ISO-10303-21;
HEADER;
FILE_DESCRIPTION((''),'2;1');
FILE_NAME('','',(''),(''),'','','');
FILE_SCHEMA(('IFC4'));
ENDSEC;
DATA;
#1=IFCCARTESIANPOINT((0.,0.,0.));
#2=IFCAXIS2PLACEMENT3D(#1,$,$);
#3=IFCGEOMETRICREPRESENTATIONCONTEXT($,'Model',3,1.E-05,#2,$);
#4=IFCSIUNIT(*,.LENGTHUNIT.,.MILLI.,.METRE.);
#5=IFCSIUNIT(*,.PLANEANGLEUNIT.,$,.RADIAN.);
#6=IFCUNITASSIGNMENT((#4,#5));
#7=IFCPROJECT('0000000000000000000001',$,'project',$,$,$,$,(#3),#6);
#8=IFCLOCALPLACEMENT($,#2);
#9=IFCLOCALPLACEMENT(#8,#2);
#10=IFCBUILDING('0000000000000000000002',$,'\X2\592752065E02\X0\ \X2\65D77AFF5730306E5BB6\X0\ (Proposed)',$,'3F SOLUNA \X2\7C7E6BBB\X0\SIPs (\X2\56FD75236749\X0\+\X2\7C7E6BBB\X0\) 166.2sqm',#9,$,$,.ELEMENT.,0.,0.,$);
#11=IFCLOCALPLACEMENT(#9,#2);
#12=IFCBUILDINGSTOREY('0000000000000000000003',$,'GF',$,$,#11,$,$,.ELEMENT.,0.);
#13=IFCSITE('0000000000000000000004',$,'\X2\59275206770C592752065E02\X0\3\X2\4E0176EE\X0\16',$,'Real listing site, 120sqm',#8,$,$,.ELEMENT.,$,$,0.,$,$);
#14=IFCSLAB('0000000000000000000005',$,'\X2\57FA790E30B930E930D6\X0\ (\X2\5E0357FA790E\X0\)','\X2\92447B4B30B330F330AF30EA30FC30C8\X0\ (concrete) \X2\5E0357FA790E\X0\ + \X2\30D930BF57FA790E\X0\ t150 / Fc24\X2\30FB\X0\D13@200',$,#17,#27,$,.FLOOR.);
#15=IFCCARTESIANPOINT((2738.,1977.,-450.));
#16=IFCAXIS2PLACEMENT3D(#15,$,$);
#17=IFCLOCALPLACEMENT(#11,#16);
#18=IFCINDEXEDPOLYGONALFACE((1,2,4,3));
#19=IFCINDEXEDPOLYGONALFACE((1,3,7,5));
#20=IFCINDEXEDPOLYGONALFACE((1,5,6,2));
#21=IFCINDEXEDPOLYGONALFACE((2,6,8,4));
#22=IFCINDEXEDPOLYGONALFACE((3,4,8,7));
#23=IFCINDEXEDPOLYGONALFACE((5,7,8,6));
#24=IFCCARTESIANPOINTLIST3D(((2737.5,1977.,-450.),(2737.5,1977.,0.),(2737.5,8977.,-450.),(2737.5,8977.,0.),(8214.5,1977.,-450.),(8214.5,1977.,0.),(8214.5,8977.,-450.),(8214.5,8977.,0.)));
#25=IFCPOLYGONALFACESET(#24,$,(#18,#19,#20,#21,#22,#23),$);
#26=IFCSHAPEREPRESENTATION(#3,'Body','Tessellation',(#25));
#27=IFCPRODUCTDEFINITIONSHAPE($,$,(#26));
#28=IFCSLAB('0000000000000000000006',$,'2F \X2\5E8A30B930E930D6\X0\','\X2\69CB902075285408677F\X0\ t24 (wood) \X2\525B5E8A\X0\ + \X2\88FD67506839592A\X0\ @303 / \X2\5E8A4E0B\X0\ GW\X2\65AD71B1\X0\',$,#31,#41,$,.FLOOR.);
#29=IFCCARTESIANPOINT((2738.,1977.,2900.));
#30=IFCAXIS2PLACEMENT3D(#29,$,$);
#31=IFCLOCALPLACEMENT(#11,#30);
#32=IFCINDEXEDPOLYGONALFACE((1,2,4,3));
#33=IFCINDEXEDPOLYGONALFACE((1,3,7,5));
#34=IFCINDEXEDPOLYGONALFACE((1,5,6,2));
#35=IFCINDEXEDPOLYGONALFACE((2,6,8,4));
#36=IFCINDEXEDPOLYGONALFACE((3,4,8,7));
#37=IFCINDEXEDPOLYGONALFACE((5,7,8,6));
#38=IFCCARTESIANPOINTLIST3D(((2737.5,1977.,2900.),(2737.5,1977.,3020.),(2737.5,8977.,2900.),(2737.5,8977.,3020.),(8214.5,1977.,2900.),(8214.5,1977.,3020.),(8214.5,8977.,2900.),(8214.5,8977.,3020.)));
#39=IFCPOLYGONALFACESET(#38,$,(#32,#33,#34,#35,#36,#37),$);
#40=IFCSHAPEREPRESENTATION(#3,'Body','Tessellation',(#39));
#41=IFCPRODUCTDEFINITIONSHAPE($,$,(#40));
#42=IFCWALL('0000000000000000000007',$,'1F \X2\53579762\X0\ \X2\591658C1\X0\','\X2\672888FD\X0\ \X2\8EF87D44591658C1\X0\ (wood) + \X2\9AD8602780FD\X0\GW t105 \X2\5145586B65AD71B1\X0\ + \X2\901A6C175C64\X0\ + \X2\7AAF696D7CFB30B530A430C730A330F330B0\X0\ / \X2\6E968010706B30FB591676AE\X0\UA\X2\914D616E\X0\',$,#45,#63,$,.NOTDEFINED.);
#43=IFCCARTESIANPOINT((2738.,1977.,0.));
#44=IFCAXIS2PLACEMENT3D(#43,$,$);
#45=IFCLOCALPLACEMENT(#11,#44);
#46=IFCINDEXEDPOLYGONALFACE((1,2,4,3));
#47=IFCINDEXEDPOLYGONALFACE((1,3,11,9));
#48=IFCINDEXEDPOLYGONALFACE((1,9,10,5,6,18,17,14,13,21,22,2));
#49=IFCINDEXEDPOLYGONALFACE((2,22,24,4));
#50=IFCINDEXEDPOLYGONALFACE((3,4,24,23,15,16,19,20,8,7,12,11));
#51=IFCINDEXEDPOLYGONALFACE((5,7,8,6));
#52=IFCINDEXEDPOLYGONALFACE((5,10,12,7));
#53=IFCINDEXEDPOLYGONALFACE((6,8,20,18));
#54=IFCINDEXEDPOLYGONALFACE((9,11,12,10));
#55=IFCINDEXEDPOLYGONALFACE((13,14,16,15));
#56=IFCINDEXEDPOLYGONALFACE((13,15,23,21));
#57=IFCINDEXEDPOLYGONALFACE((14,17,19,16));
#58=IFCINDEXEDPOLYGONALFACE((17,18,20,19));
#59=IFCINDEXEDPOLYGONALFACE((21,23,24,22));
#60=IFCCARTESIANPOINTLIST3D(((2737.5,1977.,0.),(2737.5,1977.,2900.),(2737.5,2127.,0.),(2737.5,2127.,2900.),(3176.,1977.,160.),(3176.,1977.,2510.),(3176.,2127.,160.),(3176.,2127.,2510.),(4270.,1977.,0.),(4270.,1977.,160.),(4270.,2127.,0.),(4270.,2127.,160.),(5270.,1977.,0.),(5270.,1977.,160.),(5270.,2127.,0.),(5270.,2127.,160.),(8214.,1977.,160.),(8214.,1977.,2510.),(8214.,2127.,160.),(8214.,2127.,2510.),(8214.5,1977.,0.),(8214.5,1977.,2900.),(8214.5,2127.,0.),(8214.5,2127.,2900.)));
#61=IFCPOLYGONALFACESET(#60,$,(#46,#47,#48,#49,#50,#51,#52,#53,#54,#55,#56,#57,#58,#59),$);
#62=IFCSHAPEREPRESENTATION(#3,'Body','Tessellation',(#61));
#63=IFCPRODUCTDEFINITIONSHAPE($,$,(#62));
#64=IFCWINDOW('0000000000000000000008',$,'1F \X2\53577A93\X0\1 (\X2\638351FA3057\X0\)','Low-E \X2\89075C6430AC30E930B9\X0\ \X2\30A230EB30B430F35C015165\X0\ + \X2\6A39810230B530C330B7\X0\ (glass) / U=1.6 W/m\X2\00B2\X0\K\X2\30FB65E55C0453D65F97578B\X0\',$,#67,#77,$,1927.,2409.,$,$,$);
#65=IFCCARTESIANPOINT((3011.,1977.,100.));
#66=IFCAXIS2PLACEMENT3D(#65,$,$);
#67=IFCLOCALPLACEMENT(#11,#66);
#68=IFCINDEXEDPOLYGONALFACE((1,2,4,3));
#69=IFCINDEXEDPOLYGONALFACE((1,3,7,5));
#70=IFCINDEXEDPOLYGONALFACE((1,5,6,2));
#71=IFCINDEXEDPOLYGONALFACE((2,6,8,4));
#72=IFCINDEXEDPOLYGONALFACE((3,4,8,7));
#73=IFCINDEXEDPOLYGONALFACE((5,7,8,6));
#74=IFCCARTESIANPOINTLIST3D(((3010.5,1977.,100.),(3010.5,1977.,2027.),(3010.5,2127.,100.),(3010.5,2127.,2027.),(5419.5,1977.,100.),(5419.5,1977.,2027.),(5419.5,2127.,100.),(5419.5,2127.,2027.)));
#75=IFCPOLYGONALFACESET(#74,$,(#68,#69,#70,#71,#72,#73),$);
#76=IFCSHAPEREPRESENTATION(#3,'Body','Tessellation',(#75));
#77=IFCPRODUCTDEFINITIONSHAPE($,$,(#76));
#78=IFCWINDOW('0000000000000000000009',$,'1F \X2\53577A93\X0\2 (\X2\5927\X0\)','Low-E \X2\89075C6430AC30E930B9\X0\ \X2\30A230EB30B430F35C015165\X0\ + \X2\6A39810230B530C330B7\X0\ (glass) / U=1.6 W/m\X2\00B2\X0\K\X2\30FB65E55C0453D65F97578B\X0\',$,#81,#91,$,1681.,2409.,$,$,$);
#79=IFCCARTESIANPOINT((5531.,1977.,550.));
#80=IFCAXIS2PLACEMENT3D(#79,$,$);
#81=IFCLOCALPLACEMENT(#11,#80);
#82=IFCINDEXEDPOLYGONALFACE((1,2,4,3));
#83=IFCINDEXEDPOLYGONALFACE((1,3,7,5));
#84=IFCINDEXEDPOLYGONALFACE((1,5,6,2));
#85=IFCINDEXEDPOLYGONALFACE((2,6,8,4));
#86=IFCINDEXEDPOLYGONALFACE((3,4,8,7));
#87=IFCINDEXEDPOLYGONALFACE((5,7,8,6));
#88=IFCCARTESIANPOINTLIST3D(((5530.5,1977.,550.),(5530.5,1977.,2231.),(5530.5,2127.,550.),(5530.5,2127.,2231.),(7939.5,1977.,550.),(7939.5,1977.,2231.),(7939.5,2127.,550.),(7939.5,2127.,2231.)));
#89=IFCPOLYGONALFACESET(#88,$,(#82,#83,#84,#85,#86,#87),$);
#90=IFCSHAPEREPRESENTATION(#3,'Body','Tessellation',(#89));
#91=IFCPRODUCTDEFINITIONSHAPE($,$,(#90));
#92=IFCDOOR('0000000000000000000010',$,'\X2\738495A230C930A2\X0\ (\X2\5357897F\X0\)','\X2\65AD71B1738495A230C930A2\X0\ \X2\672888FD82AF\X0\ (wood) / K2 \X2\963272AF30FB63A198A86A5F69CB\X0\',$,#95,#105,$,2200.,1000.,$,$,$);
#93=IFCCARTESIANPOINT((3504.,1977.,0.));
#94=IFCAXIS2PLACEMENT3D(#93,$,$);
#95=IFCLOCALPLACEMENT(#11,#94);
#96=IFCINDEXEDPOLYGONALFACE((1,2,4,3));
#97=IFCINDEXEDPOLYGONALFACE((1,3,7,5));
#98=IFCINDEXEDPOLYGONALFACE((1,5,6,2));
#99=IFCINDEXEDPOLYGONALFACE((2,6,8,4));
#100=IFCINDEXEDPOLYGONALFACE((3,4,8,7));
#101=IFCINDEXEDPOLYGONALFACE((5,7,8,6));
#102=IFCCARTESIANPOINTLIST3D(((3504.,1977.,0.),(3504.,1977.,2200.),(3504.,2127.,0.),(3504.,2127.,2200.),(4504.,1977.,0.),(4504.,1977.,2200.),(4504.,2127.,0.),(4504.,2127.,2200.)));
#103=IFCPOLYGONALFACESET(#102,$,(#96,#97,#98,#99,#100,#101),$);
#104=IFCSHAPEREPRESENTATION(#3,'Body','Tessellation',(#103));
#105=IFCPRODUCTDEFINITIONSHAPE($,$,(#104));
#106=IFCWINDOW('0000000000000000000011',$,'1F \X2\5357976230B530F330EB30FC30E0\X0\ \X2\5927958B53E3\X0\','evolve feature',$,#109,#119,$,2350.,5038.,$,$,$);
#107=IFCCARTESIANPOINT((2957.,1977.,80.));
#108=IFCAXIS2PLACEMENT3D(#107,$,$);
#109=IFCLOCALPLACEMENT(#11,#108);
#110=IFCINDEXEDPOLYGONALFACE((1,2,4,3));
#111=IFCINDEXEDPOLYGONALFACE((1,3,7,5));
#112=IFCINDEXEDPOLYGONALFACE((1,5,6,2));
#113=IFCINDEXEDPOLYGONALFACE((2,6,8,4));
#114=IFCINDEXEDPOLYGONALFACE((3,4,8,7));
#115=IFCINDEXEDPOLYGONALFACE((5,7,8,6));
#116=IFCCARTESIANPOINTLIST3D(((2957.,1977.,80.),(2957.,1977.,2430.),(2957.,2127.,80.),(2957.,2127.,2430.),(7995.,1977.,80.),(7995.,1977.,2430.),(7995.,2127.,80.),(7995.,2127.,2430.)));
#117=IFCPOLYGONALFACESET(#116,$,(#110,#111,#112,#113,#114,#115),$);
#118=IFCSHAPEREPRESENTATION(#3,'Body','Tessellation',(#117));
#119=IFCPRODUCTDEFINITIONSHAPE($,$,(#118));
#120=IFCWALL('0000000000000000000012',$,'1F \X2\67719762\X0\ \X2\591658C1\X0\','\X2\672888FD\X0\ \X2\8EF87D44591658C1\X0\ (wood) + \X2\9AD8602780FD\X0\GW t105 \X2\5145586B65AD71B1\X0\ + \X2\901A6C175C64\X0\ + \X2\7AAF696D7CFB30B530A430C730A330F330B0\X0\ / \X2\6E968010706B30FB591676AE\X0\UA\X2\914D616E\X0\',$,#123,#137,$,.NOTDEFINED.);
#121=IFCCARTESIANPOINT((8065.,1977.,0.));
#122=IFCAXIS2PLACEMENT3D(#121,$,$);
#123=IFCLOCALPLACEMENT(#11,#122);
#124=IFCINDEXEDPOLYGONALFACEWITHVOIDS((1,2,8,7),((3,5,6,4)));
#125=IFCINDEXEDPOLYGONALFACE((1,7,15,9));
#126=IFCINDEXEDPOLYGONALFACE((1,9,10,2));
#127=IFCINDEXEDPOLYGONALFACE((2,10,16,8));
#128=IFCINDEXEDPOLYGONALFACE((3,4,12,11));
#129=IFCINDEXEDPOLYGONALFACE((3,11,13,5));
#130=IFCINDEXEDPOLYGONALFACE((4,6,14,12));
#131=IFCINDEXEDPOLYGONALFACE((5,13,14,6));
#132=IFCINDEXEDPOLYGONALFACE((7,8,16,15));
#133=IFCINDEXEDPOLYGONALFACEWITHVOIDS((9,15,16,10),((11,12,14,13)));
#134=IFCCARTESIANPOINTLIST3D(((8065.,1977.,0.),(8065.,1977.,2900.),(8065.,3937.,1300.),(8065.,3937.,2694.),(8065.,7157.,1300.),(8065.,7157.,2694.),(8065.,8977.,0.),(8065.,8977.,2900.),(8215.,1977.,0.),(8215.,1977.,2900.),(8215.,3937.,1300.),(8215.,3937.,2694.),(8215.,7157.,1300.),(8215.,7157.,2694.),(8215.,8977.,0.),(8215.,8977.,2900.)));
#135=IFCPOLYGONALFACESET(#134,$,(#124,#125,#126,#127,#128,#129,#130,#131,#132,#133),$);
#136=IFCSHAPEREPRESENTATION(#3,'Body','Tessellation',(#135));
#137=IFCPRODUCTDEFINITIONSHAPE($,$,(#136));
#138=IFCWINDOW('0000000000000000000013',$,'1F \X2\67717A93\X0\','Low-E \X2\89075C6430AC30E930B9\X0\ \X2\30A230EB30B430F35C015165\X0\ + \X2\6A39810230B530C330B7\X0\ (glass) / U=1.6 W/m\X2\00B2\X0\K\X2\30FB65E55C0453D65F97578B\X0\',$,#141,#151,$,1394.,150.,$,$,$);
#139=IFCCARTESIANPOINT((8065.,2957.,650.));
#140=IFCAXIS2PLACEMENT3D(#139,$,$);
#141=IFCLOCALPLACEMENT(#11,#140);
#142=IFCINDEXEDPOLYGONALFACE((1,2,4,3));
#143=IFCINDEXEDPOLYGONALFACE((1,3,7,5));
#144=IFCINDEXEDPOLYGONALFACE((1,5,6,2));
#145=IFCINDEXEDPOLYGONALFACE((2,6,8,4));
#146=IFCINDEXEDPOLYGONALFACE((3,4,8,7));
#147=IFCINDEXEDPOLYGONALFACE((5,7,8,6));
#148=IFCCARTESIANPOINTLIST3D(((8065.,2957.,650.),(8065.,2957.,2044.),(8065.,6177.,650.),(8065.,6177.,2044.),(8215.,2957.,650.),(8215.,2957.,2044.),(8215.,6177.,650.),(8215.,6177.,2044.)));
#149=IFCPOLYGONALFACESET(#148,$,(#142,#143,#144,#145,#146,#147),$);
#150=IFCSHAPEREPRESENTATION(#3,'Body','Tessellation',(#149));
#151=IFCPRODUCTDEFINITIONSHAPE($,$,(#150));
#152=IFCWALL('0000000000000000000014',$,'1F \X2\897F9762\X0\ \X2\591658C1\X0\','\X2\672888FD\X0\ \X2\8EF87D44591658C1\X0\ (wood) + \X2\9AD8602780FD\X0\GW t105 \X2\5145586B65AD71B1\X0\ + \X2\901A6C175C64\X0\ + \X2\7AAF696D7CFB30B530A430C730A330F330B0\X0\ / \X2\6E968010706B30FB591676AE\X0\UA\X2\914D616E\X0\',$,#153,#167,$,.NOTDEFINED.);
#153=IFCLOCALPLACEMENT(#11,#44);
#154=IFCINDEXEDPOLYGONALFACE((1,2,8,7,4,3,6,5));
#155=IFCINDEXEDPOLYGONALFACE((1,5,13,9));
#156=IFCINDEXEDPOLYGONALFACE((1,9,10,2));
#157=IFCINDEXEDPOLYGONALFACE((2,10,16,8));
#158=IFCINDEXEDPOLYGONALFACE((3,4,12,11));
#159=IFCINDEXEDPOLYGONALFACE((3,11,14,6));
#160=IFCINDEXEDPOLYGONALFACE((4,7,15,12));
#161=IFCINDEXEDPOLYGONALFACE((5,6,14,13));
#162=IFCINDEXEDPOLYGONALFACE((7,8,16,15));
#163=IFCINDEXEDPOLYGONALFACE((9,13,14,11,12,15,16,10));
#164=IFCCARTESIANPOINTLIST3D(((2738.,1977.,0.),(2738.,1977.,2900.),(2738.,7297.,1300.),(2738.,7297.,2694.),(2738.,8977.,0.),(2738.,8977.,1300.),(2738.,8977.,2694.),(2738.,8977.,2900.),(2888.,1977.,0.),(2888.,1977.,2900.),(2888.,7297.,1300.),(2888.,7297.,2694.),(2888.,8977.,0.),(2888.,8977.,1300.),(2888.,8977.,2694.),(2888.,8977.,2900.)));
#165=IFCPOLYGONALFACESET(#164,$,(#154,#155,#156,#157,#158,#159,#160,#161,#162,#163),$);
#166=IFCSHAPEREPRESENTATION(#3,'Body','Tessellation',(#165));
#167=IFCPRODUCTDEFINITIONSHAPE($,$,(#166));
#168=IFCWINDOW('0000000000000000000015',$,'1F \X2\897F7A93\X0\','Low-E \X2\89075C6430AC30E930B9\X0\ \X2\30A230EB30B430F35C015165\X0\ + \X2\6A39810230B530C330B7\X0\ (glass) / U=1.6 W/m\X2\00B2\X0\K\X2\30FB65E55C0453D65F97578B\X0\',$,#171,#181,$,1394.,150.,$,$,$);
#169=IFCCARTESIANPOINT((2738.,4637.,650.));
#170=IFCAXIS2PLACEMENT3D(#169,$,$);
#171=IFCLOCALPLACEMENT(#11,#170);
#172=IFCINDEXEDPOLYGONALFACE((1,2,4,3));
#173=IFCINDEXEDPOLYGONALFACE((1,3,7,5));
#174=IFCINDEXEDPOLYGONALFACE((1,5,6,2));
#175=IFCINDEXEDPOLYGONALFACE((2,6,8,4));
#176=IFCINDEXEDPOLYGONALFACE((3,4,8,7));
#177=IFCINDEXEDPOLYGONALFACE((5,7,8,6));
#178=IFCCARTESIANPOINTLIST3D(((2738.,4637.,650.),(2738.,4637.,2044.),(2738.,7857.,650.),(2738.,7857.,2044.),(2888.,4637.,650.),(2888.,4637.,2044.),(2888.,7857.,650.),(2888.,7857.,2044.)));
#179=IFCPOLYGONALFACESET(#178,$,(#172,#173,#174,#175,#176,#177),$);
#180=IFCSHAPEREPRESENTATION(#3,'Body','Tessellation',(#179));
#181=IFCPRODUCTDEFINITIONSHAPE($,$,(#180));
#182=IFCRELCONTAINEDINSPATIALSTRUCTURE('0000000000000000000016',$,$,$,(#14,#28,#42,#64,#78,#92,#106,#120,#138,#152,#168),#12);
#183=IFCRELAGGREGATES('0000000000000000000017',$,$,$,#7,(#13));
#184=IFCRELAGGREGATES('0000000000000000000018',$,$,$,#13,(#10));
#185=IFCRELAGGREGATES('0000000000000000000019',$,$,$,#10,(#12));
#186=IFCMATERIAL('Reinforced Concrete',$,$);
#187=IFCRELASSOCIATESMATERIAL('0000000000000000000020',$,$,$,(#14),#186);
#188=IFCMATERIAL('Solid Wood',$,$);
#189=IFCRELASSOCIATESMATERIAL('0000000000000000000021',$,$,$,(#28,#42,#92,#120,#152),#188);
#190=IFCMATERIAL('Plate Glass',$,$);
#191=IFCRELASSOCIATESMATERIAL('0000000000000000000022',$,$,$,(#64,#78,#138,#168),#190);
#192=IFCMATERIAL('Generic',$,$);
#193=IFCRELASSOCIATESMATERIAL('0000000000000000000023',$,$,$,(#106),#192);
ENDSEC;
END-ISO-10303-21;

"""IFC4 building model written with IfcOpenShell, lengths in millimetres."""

from ifc_helpers import new_model, si_unit, frame, frame_2d, origin, place, context, project, spatial, rectangle, extrude, material, element, fill, save


model = new_model("IFC4")

# Units and contexts
model_context = context("Model", 3, precision=1e-05, world=origin())
ifc_project = project(units=[si_unit("LENGTHUNIT", "METRE", prefix="MILLI"), si_unit("PLANEANGLEUNIT", "RADIAN")], contexts=[model_context])

# Site, building, storey
site_placement = place(None, origin())
site = spatial("IfcSite", under=ifc_project, at=site_placement, Name="大分県大分市3丁目16", ObjectType="Real listing site, 120sqm", CompositionType="ELEMENT", RefElevation=0.0)
building_placement = place(site_placement, origin())
building = spatial("IfcBuilding", under=site, at=building_placement, Name="大分市 旗竿地の家 (Proposed)", ObjectType="3F SOLUNA 籾殻SIPs (国産杉+籾殻) 166.2sqm", CompositionType="ELEMENT", ElevationOfRefHeight=0.0, ElevationOfTerrain=0.0)
storey_placement = place(building_placement, origin())
storey = spatial("IfcBuildingStorey", under=building, at=storey_placement, Name="GF", CompositionType="ELEMENT", Elevation=0.0)

# Slabs
ifc_material_1 = material(Name="Reinforced Concrete")
slab_1_placement = place(storey_placement, frame((2738.0, 1977.0, -450.0)))
element("IfcSlab", 1, at=slab_1_placement, inside=storey, material=ifc_material_1, Name="基礎スラブ (布基礎)", Description="鉄筋コンクリート (concrete) 布基礎 + ベタ基礎 t150 / Fc24・D13@200", PredefinedType="FLOOR", context=model_context, shape_type="SweptSolid", body=[
    extrude(rectangle(XDim=5477.0, YDim=7000.0, at=frame_2d((2738.0, 3500.0))), frame((2738.0, 1977.0, -450.0)), (0.0, 0.0, 1.0), 450.0),
])
ifc_material_2 = material(Name="Solid Wood")
slab_2_placement = place(storey_placement, frame((2738.0, 1977.0, 2900.0)))
element("IfcSlab", 2, at=slab_2_placement, inside=storey, material=ifc_material_2, Name="2F 床スラブ", Description="構造用合板 t24 (wood) 剛床 + 製材根太 @303 / 床下 GW断熱", PredefinedType="FLOOR", context=model_context, shape_type="SweptSolid", body=[
    extrude(rectangle(XDim=5477.0, YDim=7000.0, at=frame_2d((2738.0, 3500.0))), frame((2738.0, 1977.0, 2900.0)), (0.0, 0.0, 1.0), 120.0),
])
ifc_material_3 = material(Name="Generic")

# Wall, openings, windows, door
wall_1_placement = place(storey_placement, frame((2738.0, 1977.0, 0.0)))
wall_1 = element("IfcWall", 3, at=wall_1_placement, inside=storey, material=ifc_material_2, Name="1F 南面 外壁", Description="木製 軸組外壁 (wood) + 高性能GW t105 充填断熱 + 通気層 + 窯業系サイディング / 準耐火・外皮UA配慮", PredefinedType="NOTDEFINED", context=model_context, shape_type="SweptSolid", body=[
    extrude(rectangle(XDim=5477.0, YDim=150.0, at=frame_2d((2738.0, 75.0))), frame((2738.0, 1977.0, 0.0)), (0.0, 0.0, 1.0), 2900.0),
])
opening_1_placement = place(storey_placement, frame((3011.0, 1977.0, 100.0)))
opening_1 = element("IfcOpeningElement", 4, at=opening_1_placement, cuts=wall_1, PredefinedType="NOTDEFINED", context=model_context, shape_type="SweptSolid", body=[
    extrude(rectangle(XDim=2409.0, YDim=150.0, at=frame_2d((1204.0, 75.0))), frame((3011.0, 1977.0, 100.0)), (0.0, 0.0, 1.0), 1927.0),
])
opening_2_placement = place(storey_placement, frame((5531.0, 1977.0, 550.0)))
opening_2 = element("IfcOpeningElement", 5, at=opening_2_placement, cuts=wall_1, PredefinedType="NOTDEFINED", context=model_context, shape_type="SweptSolid", body=[
    extrude(rectangle(XDim=2409.0, YDim=150.0, at=frame_2d((1204.0, 75.0))), frame((5531.0, 1977.0, 550.0)), (0.0, 0.0, 1.0), 1681.0),
])
opening_3_placement = place(storey_placement, frame((3504.0, 1977.0, 0.0)))
opening_3 = element("IfcOpeningElement", 6, at=opening_3_placement, cuts=wall_1, PredefinedType="NOTDEFINED", context=model_context, shape_type="SweptSolid", body=[
    extrude(rectangle(XDim=1000.0, YDim=150.0, at=frame_2d((500.0, 75.0))), frame((3504.0, 1977.0, 0.0)), (0.0, 0.0, 1.0), 2200.0),
])
opening_4_placement = place(storey_placement, frame((2957.0, 1977.0, 80.0)))
opening_4 = element("IfcOpeningElement", 7, at=opening_4_placement, cuts=wall_1, PredefinedType="NOTDEFINED", context=model_context, shape_type="SweptSolid", body=[
    extrude(rectangle(XDim=5038.0, YDim=150.0, at=frame_2d((2519.0, 75.0))), frame((2957.0, 1977.0, 80.0)), (0.0, 0.0, 1.0), 2350.0),
])
ifc_material_4 = material(Name="Plate Glass")
window_1_placement = place(storey_placement, frame((3011.0, 1977.0, 100.0)))
window_1 = element("IfcWindow", 8, at=window_1_placement, inside=storey, material=ifc_material_4, Name="1F 南窓1 (掃出し)", Description="Low-E 複層ガラス アルゴン封入 + 樹脂サッシ (glass) / U=1.6 W/m²K・日射取得型", OverallHeight=1927.0, OverallWidth=2409.0, context=model_context, shape_type="SweptSolid", body=[
    extrude(rectangle(XDim=2409.0, YDim=150.0, at=frame_2d((1204.0, 75.0))), frame((3011.0, 1977.0, 100.0)), (0.0, 0.0, 1.0), 1927.0),
])
fill(opening_1, window_1)
window_2_placement = place(storey_placement, frame((5531.0, 1977.0, 550.0)))
window_2 = element("IfcWindow", 9, at=window_2_placement, inside=storey, material=ifc_material_4, Name="1F 南窓2 (大)", Description="Low-E 複層ガラス アルゴン封入 + 樹脂サッシ (glass) / U=1.6 W/m²K・日射取得型", OverallHeight=1681.0, OverallWidth=2409.0, context=model_context, shape_type="SweptSolid", body=[
    extrude(rectangle(XDim=2409.0, YDim=150.0, at=frame_2d((1204.0, 75.0))), frame((5531.0, 1977.0, 550.0)), (0.0, 0.0, 1.0), 1681.0),
])
fill(opening_2, window_2)
door_placement = place(storey_placement, frame((3504.0, 1977.0, 0.0)))
door = element("IfcDoor", 10, at=door_placement, inside=storey, material=ifc_material_2, Name="玄関ドア (南西)", Description="断熱玄関ドア 木製芯 (wood) / K2 防犯・採風機構", OverallHeight=2200.0, OverallWidth=1000.0, context=model_context, shape_type="SweptSolid", body=[
    extrude(rectangle(XDim=1000.0, YDim=150.0, at=frame_2d((500.0, 75.0))), frame((3504.0, 1977.0, 0.0)), (0.0, 0.0, 1.0), 2200.0),
])
fill(opening_3, door)
window_3_placement = place(storey_placement, frame((2957.0, 1977.0, 80.0)))
window_3 = element("IfcWindow", 11, at=window_3_placement, inside=storey, material=ifc_material_3, Name="1F 南面サンルーム 大開口", Description="evolve feature", OverallHeight=2350.0, OverallWidth=5038.0, context=model_context, shape_type="SweptSolid", body=[
    extrude(rectangle(XDim=5038.0, YDim=150.0, at=frame_2d((2519.0, 75.0))), frame((2957.0, 1977.0, 80.0)), (0.0, 0.0, 1.0), 2350.0),
])
fill(opening_4, window_3)

# Walls, openings, windows
wall_2_placement = place(storey_placement, frame((8065.0, 1977.0, 0.0)))
wall_2 = element("IfcWall", 12, at=wall_2_placement, inside=storey, material=ifc_material_2, Name="1F 東面 外壁", Description="木製 軸組外壁 (wood) + 高性能GW t105 充填断熱 + 通気層 + 窯業系サイディング / 準耐火・外皮UA配慮", PredefinedType="NOTDEFINED", context=model_context, shape_type="SweptSolid", body=[
    extrude(rectangle(XDim=150.0, YDim=7000.0, at=frame_2d((75.0, 3500.0))), frame((8065.0, 1977.0, 0.0)), (0.0, 0.0, 1.0), 2900.0),
])
opening_5_placement = place(storey_placement, frame((8065.0, 2957.0, 650.0)))
opening_5 = element("IfcOpeningElement", 13, at=opening_5_placement, cuts=wall_2, PredefinedType="NOTDEFINED", context=model_context, shape_type="SweptSolid", body=[
    extrude(rectangle(XDim=150.0, YDim=3220.0, at=frame_2d((75.0, 1610.0))), frame((8065.0, 2957.0, 650.0)), (0.0, 0.0, 1.0), 1394.0),
])
window_4_placement = place(storey_placement, frame((8065.0, 2957.0, 650.0)))
window_4 = element("IfcWindow", 14, at=window_4_placement, inside=storey, material=ifc_material_4, Name="1F 東窓", Description="Low-E 複層ガラス アルゴン封入 + 樹脂サッシ (glass) / U=1.6 W/m²K・日射取得型", OverallHeight=1394.0, OverallWidth=150.0, context=model_context, shape_type="SweptSolid", body=[
    extrude(rectangle(XDim=150.0, YDim=3220.0, at=frame_2d((75.0, 1610.0))), frame((8065.0, 2957.0, 650.0)), (0.0, 0.0, 1.0), 1394.0),
])
fill(opening_5, window_4)
wall_3_placement = place(storey_placement, frame((2738.0, 1977.0, 0.0)))
wall_3 = element("IfcWall", 15, at=wall_3_placement, inside=storey, material=ifc_material_2, Name="1F 西面 外壁", Description="木製 軸組外壁 (wood) + 高性能GW t105 充填断熱 + 通気層 + 窯業系サイディング / 準耐火・外皮UA配慮", PredefinedType="NOTDEFINED", context=model_context, shape_type="SweptSolid", body=[
    extrude(rectangle(XDim=150.0, YDim=7000.0, at=frame_2d((75.0, 3500.0))), frame((2738.0, 1977.0, 0.0)), (0.0, 0.0, 1.0), 2900.0),
])
opening_6_placement = place(storey_placement, frame((2738.0, 4637.0, 650.0)))
opening_6 = element("IfcOpeningElement", 16, at=opening_6_placement, cuts=wall_3, PredefinedType="NOTDEFINED", context=model_context, shape_type="SweptSolid", body=[
    extrude(rectangle(XDim=150.0, YDim=3220.0, at=frame_2d((75.0, 1610.0))), frame((2738.0, 4637.0, 650.0)), (0.0, 0.0, 1.0), 1394.0),
])
window_5_placement = place(storey_placement, frame((2738.0, 4637.0, 650.0)))
window_5 = element("IfcWindow", 17, at=window_5_placement, inside=storey, material=ifc_material_4, Name="1F 西窓", Description="Low-E 複層ガラス アルゴン封入 + 樹脂サッシ (glass) / U=1.6 W/m²K・日射取得型", OverallHeight=1394.0, OverallWidth=150.0, context=model_context, shape_type="SweptSolid", body=[
    extrude(rectangle(XDim=150.0, YDim=3220.0, at=frame_2d((75.0, 1610.0))), frame((2738.0, 4637.0, 650.0)), (0.0, 0.0, 1.0), 1394.0),
])
fill(opening_6, window_5)

save(model, "model.ifc")
